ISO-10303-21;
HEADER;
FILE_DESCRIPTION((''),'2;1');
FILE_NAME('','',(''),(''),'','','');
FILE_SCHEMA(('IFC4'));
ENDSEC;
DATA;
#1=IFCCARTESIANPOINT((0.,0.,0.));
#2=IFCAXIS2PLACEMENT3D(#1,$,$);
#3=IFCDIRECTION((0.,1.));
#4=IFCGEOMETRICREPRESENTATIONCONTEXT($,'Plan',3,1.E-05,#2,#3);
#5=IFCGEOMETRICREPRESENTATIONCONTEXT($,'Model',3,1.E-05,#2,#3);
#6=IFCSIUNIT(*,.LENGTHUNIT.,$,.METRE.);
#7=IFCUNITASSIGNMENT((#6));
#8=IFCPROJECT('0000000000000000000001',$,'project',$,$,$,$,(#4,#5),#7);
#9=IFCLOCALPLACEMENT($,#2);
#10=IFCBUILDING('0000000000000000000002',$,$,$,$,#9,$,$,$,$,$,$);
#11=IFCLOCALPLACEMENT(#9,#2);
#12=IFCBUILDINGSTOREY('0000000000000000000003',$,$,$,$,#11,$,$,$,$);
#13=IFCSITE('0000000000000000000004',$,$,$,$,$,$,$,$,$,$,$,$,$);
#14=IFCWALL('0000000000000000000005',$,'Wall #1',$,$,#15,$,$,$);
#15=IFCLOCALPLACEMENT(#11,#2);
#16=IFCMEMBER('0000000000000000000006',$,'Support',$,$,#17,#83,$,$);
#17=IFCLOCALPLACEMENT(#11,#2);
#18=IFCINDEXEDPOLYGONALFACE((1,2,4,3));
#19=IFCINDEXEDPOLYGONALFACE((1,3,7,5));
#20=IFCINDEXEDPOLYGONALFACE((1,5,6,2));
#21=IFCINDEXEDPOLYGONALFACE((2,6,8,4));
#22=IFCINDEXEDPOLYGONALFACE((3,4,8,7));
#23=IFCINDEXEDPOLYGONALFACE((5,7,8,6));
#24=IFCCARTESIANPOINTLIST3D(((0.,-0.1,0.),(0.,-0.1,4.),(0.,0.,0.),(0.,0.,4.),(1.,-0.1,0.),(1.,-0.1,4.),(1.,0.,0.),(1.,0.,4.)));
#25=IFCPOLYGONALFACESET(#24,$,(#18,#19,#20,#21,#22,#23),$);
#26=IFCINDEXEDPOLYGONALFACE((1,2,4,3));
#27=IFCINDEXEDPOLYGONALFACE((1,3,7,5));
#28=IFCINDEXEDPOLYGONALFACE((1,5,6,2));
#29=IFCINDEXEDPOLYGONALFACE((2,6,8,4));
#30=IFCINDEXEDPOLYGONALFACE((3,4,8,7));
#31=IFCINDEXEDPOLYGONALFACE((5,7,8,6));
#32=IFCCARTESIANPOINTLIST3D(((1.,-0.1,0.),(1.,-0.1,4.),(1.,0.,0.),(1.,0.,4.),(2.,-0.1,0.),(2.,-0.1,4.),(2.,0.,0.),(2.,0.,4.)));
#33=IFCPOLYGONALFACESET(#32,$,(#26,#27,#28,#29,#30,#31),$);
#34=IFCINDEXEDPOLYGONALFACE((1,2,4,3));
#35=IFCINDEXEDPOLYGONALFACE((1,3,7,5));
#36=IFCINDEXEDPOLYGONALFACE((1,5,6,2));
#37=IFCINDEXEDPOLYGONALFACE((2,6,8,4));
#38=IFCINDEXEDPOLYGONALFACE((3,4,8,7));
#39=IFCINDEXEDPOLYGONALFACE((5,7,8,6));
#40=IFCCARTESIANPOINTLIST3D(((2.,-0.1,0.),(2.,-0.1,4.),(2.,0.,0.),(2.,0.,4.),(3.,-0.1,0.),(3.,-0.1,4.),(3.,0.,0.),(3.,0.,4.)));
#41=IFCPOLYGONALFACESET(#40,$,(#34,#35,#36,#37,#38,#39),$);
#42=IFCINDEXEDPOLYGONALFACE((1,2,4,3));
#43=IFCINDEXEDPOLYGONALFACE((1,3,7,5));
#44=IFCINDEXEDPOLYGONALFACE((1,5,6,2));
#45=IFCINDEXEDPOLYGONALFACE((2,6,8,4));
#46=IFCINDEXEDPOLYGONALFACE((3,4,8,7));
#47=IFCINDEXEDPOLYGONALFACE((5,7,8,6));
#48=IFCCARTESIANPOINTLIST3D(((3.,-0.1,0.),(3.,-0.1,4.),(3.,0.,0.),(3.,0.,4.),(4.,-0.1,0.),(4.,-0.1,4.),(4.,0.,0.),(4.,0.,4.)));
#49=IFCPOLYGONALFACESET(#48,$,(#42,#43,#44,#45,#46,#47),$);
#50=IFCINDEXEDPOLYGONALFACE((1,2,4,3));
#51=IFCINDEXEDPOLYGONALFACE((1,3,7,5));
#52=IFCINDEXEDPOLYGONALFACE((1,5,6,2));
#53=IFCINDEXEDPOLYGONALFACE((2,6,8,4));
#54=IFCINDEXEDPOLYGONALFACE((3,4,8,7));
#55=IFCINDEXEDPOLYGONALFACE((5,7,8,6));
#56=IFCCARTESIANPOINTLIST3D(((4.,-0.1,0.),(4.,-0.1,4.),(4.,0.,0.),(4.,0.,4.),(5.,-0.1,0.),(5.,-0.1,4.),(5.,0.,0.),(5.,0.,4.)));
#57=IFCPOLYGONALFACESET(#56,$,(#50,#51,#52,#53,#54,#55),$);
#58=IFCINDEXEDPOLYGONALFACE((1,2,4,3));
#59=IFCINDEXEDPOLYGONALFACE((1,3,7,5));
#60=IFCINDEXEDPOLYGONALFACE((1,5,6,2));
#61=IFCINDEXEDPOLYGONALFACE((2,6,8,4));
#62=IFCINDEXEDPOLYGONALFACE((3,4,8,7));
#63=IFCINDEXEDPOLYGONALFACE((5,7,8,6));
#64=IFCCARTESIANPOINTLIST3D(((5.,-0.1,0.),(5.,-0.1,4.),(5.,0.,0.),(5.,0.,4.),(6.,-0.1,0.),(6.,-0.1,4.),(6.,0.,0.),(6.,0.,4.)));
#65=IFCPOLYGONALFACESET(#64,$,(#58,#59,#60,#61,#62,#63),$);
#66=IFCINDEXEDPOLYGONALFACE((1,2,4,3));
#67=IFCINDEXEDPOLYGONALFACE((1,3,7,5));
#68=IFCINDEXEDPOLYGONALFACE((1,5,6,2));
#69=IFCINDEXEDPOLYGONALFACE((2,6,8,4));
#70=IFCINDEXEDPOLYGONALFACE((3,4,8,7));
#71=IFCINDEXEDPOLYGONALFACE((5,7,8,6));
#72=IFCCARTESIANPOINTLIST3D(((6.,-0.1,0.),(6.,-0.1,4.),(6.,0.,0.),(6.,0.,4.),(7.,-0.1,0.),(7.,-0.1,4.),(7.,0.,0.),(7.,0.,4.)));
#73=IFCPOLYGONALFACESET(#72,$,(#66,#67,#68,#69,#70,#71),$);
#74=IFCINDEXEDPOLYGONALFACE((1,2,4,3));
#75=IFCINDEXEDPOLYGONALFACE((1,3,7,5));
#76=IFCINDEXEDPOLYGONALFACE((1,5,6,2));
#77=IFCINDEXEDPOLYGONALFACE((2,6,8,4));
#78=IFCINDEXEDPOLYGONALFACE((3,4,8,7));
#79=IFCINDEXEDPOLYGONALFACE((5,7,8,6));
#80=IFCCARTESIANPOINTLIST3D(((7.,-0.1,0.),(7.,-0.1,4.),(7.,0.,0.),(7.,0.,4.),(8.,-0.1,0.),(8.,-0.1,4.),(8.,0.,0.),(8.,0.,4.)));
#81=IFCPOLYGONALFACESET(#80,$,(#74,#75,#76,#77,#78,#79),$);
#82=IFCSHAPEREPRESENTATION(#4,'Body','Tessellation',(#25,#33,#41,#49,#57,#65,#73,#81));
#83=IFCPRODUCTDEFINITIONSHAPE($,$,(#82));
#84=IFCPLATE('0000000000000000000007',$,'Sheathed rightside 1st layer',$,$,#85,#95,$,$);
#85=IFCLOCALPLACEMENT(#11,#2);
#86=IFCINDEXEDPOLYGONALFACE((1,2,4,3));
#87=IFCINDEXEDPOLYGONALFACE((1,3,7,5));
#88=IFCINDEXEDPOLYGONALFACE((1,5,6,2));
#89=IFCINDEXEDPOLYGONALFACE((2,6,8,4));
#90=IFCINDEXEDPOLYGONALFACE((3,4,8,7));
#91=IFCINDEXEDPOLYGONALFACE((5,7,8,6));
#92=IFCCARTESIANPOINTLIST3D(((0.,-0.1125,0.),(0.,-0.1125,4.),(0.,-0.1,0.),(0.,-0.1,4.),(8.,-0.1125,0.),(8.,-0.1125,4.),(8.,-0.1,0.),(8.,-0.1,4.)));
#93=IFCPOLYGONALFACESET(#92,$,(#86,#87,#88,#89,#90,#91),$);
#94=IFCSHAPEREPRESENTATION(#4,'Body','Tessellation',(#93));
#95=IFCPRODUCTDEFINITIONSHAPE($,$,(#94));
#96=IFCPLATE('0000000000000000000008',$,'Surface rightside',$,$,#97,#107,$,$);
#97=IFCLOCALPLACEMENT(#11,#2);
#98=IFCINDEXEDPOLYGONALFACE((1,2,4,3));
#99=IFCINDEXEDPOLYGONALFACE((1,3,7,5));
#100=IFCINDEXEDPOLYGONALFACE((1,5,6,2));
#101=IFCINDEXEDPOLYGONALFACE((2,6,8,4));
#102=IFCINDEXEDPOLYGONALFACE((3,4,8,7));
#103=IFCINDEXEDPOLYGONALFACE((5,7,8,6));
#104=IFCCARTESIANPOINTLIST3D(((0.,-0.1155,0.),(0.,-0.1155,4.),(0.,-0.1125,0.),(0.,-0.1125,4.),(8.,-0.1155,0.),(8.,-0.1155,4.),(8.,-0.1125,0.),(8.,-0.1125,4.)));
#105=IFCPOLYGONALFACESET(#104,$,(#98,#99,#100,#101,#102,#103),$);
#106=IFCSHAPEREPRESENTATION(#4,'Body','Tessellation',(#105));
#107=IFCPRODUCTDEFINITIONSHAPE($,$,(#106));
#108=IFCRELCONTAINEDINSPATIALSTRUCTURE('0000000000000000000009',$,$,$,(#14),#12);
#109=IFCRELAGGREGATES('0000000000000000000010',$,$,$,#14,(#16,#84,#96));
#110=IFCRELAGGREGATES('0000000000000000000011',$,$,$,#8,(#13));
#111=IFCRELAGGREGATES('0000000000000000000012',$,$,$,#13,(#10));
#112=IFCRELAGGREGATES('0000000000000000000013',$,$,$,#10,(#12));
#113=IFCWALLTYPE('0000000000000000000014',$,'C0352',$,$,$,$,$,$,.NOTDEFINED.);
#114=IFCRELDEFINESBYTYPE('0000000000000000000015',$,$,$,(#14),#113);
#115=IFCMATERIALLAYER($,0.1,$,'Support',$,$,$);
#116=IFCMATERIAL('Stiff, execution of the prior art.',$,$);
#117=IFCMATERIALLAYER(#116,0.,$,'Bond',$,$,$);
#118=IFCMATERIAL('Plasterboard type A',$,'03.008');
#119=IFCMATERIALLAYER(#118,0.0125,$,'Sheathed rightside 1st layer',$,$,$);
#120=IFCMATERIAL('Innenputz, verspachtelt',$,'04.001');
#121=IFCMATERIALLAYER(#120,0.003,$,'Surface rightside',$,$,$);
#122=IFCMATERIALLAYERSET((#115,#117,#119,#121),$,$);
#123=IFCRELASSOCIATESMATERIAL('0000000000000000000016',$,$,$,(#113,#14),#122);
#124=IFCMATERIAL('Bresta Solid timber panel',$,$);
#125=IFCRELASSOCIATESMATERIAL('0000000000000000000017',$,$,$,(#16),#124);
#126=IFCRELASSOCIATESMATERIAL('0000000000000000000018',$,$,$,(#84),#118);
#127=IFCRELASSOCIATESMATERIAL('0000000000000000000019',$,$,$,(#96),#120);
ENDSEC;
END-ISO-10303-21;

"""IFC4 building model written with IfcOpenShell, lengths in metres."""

from ifc_helpers import new_model, si_unit, direction, frame, frame_2d, origin, place, context, project, spatial, rectangle, extrude, material, layer, layer_set, type_object, element, aggregate, save


model = new_model("IFC4")

# Units and contexts
plan_context = context("Plan", 3, precision=1e-05, world=origin(), true_north=direction((0.0, 1.0)))
model_context = context("Model", 3, precision=1e-05, world=origin(), true_north=direction((0.0, 1.0)))
ifc_project = project(units=[si_unit("LENGTHUNIT", "METRE")], contexts=[plan_context, model_context])

# Site, building, storey
site = spatial("IfcSite", under=ifc_project)
building_placement = place(None, origin())
building = spatial("IfcBuilding", under=site, at=building_placement)
storey_placement = place(building_placement, origin())
storey = spatial("IfcBuildingStorey", under=building, at=storey_placement)

# Wall, member, plates
ifc_layer_1 = layer(None, 0.1, Name="Support")
ifc_material_1 = material(Name="Stiff, execution of the prior art.")
ifc_layer_2 = layer(ifc_material_1, 0.0, Name="Bond")
ifc_material_2 = material(Name="Plasterboard type A", Category="03.008")
ifc_layer_3 = layer(ifc_material_2, 0.0125, Name="Sheathed rightside 1st layer")
ifc_material_3 = material(Name="Innenputz, verspachtelt", Category="04.001")
ifc_layer_4 = layer(ifc_material_3, 0.003, Name="Surface rightside")
ifc_layer_set = layer_set([ifc_layer_1, ifc_layer_2, ifc_layer_3, ifc_layer_4])
wall_type = type_object("IfcWallType", Name="C0352", PredefinedType="NOTDEFINED", material=ifc_layer_set)
wall_placement = place(None, frame((0.0, 0.0, 0.0), z_axis=(0.0, -1.0, 0.0), x_axis=(1.0, 0.0, 0.0)))
wall = element("IfcWall", 1, at=wall_placement, inside=storey, type_object=wall_type, material=ifc_layer_set, Name="Wall #1")
ifc_material_4 = material(Name="Bresta Solid timber panel")
member_placement = place(wall_placement, origin())
member = element("IfcMember", 2, at=member_placement, material=ifc_material_4, Name="Support", context=plan_context, shape_type="SweptSolid", body=[
    extrude(rectangle(XDim=1.0, YDim=0.1, at=frame_2d((0.5, 0.05), x_axis=(1.0, 0.0))), frame((0.0, 4.0, 0.0), z_axis=(0.0, -1.0, 0.0), x_axis=(1.0, 0.0, 0.0)), (0.0, 0.0, 1.0), 4.0),
    extrude(rectangle(XDim=1.0, YDim=0.1, at=frame_2d((0.5, 0.05), x_axis=(1.0, 0.0))), frame((1.0, 4.0, 0.0), z_axis=(0.0, -1.0, 0.0), x_axis=(1.0, 0.0, 0.0)), (0.0, 0.0, 1.0), 4.0),
    extrude(rectangle(XDim=1.0, YDim=0.1, at=frame_2d((0.5, 0.05), x_axis=(1.0, 0.0))), frame((2.0, 4.0, 0.0), z_axis=(0.0, -1.0, 0.0), x_axis=(1.0, 0.0, 0.0)), (0.0, 0.0, 1.0), 4.0),
    extrude(rectangle(XDim=1.0, YDim=0.1, at=frame_2d((0.5, 0.05), x_axis=(1.0, 0.0))), frame((3.0, 4.0, 0.0), z_axis=(0.0, -1.0, 0.0), x_axis=(1.0, 0.0, 0.0)), (0.0, 0.0, 1.0), 4.0),
    extrude(rectangle(XDim=1.0, YDim=0.1, at=frame_2d((0.5, 0.05), x_axis=(1.0, 0.0))), frame((4.0, 4.0, 0.0), z_axis=(0.0, -1.0, 0.0), x_axis=(1.0, 0.0, 0.0)), (0.0, 0.0, 1.0), 4.0),
    extrude(rectangle(XDim=1.0, YDim=0.1, at=frame_2d((0.5, 0.05), x_axis=(1.0, 0.0))), frame((5.0, 4.0, 0.0), z_axis=(0.0, -1.0, 0.0), x_axis=(1.0, 0.0, 0.0)), (0.0, 0.0, 1.0), 4.0),
    extrude(rectangle(XDim=1.0, YDim=0.1, at=frame_2d((0.5, 0.05), x_axis=(1.0, 0.0))), frame((6.0, 4.0, 0.0), z_axis=(0.0, -1.0, 0.0), x_axis=(1.0, 0.0, 0.0)), (0.0, 0.0, 1.0), 4.0),
    extrude(rectangle(XDim=1.0, YDim=0.1, at=frame_2d((0.5, 0.05), x_axis=(1.0, 0.0))), frame((7.0, 4.0, 0.0), z_axis=(0.0, -1.0, 0.0), x_axis=(1.0, 0.0, 0.0)), (0.0, 0.0, 1.0), 4.0),
])
plate_1_placement = place(wall_placement, origin())
plate_1 = element("IfcPlate", 3, at=plate_1_placement, material=ifc_material_2, Name="Sheathed rightside 1st layer", context=plan_context, shape_type="SweptSolid", body=[
    extrude(rectangle(XDim=8.0, YDim=4.0, at=frame_2d((4.0, 2.0), x_axis=(1.0, 0.0))), frame((0.0, 0.0, 0.1), z_axis=(0.0, 0.0, 1.0), x_axis=(1.0, 0.0, 0.0)), (0.0, 0.0, 1.0), 0.0125),
])
plate_2_placement = place(wall_placement, origin())
plate_2 = element("IfcPlate", 4, at=plate_2_placement, material=ifc_material_3, Name="Surface rightside", context=plan_context, shape_type="SweptSolid", body=[
    extrude(rectangle(XDim=8.0, YDim=4.0, at=frame_2d((4.0, 2.0), x_axis=(1.0, 0.0))), frame((0.0, 0.0, 0.1125), z_axis=(0.0, 0.0, 1.0), x_axis=(1.0, 0.0, 0.0)), (0.0, 0.0, 1.0), 0.003),
])
aggregate(wall, [member, plate_1, plate_2])

save(model, "model.ifc")
